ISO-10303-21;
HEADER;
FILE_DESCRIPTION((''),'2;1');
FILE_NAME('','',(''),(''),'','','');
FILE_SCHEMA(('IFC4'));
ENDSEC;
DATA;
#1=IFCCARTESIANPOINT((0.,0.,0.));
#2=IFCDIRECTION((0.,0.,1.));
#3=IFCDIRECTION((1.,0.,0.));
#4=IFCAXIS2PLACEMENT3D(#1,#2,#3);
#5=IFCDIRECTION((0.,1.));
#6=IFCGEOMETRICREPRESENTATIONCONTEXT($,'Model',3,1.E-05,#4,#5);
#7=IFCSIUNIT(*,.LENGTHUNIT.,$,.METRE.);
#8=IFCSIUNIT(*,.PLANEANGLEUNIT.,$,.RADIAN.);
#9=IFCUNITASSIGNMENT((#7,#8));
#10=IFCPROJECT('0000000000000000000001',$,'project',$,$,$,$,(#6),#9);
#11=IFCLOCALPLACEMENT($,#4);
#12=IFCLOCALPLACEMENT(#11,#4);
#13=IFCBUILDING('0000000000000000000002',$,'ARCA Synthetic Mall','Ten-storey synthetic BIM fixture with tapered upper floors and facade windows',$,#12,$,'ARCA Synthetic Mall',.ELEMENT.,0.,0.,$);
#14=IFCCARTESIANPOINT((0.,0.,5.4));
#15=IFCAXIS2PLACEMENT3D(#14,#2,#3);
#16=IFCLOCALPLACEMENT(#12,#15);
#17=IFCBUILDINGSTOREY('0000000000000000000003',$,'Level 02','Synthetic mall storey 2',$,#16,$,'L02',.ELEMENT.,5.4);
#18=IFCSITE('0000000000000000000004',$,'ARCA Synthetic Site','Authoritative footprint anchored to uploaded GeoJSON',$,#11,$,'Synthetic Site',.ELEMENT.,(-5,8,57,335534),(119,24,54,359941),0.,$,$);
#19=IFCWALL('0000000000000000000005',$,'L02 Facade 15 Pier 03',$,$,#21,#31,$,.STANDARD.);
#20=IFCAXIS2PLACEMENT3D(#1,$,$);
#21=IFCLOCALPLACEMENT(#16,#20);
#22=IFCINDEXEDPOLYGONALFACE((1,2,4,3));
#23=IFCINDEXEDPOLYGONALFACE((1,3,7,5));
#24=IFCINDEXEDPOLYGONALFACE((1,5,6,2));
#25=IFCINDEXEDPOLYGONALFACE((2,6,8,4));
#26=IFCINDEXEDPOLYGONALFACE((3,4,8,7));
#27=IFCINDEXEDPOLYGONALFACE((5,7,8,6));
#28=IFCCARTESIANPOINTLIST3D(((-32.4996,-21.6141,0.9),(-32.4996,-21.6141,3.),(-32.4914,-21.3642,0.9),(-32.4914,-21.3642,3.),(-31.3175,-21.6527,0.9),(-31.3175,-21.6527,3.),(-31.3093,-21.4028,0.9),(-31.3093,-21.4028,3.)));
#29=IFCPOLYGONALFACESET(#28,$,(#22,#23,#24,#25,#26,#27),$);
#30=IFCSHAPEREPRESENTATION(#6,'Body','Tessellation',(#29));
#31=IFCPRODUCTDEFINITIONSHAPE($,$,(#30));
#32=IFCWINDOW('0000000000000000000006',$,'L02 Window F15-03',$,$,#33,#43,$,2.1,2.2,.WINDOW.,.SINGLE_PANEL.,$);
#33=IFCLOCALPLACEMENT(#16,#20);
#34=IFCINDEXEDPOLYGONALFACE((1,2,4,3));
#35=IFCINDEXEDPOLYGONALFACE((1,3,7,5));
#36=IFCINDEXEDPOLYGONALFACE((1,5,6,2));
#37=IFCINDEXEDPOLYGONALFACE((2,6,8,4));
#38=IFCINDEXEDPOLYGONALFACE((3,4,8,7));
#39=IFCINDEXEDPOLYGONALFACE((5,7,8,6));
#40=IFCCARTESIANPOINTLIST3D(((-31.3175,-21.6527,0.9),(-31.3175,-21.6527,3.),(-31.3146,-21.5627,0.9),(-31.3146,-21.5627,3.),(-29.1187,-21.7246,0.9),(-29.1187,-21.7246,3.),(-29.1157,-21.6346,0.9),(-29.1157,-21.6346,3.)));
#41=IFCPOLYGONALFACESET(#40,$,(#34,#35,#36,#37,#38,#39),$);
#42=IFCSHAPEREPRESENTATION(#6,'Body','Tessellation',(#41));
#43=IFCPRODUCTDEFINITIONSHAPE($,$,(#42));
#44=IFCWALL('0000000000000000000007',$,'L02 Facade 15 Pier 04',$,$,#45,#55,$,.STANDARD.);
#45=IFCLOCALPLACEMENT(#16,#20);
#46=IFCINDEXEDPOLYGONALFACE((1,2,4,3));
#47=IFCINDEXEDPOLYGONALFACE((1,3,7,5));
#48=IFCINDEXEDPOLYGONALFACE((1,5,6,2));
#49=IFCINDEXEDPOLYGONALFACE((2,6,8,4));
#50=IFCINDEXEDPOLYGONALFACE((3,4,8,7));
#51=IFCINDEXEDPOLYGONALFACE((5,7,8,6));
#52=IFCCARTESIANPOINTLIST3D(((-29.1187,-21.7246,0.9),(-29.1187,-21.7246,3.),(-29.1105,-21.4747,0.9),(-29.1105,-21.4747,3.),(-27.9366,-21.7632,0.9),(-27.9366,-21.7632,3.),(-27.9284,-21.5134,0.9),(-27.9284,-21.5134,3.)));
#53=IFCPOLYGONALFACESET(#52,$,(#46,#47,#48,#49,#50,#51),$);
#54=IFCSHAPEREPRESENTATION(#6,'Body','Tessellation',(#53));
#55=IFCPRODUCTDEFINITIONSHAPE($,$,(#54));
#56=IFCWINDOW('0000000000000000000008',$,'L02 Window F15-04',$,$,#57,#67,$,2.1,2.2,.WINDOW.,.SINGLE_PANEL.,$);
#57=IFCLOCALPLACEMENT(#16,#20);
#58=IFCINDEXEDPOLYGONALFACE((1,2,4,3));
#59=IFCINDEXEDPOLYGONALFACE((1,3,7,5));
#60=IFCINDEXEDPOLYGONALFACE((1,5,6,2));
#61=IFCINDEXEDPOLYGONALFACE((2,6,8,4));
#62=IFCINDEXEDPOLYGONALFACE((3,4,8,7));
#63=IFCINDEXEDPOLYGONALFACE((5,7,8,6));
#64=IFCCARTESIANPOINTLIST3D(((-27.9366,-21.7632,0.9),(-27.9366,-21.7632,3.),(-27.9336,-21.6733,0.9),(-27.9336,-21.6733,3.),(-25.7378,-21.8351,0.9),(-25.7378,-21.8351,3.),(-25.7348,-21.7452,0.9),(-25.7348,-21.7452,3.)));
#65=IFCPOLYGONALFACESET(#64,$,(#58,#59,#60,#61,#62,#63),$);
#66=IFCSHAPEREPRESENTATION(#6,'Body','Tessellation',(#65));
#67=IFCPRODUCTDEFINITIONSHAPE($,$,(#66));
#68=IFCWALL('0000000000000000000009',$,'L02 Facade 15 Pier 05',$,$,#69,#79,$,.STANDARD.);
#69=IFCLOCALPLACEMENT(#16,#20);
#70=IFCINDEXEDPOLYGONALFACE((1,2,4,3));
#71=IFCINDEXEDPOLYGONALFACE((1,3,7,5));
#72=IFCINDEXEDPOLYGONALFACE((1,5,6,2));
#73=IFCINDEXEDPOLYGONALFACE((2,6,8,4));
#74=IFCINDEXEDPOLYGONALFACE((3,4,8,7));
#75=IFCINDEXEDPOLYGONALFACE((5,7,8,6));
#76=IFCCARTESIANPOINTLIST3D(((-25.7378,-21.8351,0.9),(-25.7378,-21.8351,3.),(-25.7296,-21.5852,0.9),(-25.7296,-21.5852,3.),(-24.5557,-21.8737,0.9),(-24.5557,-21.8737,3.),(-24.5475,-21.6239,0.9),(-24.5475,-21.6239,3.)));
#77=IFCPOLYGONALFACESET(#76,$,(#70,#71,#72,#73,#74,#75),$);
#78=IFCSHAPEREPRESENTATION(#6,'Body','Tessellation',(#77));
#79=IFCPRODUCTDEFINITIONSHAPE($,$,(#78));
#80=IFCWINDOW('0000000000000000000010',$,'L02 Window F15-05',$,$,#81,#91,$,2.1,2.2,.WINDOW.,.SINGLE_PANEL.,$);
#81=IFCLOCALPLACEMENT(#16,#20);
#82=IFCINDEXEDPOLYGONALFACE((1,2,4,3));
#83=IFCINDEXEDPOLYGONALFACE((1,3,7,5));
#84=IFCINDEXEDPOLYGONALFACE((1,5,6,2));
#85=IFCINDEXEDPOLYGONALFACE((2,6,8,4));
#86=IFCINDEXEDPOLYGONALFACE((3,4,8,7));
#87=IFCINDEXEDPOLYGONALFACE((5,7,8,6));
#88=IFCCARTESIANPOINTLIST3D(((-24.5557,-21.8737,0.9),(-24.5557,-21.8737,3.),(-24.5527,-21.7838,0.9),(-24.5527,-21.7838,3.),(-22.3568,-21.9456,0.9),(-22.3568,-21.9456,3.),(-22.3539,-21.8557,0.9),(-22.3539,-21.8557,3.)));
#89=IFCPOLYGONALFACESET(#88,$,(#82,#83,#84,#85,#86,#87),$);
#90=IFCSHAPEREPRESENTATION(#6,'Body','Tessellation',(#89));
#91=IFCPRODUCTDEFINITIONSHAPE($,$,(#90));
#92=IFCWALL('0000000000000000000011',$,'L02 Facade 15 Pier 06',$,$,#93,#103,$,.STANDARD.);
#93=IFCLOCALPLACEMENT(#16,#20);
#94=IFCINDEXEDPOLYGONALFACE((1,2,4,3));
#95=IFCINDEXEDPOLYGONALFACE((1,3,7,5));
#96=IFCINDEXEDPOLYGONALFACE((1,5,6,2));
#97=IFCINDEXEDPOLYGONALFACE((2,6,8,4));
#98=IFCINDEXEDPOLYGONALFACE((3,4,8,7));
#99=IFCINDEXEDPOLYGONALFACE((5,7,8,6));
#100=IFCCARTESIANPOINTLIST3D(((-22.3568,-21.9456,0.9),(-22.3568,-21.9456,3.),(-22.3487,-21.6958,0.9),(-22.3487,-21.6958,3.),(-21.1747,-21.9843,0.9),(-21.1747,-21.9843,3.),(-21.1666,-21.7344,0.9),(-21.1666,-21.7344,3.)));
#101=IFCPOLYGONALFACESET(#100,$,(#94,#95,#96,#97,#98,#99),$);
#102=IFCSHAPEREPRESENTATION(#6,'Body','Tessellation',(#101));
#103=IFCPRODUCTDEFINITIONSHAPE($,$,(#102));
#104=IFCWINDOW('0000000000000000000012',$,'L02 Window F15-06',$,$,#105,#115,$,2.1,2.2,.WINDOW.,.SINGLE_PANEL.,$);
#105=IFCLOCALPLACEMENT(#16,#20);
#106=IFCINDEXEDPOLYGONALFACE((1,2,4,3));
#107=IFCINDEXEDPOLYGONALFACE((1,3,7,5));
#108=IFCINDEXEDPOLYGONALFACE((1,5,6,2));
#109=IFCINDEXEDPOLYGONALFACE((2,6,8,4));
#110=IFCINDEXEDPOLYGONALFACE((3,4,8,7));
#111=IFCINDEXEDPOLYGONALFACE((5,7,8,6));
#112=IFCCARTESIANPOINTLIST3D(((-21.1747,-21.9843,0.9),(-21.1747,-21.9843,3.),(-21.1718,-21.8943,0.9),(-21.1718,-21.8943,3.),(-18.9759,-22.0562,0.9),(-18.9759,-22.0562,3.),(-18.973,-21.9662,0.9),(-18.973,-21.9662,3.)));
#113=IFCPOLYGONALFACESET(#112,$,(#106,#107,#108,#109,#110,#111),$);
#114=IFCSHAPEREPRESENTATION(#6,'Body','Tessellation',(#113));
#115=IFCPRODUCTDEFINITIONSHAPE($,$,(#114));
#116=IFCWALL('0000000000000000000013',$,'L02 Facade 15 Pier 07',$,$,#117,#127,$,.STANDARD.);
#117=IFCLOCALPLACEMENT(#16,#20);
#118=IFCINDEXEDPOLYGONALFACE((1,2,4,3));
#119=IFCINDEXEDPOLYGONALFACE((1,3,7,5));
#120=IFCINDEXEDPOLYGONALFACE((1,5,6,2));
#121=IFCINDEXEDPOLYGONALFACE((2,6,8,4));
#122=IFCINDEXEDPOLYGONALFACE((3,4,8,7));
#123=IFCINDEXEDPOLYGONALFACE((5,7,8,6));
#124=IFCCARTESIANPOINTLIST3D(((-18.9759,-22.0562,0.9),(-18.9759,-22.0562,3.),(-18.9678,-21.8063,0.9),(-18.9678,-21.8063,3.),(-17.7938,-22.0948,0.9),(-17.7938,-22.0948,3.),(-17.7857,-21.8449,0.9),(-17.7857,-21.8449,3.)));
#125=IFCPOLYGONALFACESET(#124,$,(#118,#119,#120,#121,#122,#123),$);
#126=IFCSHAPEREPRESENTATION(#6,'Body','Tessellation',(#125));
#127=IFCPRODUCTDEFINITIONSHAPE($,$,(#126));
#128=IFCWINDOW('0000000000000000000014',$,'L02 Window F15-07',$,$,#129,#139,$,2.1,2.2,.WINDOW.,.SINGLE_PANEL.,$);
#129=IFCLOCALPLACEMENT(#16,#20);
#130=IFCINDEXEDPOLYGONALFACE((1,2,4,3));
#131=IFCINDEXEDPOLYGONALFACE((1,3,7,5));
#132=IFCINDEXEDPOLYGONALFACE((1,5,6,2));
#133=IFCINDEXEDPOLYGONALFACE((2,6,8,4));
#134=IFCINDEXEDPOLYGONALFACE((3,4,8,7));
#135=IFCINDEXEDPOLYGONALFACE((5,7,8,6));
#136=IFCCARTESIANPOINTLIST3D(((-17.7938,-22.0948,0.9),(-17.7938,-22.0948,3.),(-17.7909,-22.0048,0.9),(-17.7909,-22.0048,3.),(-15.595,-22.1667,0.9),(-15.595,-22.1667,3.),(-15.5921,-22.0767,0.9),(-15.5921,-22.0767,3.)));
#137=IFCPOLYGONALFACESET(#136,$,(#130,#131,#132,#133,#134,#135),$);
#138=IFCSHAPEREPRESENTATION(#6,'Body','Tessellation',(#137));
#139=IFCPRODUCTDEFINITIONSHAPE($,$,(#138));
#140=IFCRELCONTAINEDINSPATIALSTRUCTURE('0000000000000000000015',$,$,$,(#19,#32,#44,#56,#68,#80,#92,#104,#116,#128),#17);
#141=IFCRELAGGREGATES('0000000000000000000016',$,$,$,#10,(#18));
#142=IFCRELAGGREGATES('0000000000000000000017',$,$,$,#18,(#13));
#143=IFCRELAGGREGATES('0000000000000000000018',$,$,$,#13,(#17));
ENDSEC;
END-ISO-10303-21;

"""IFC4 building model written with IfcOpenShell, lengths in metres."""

from ifc_helpers import new_model, si_unit, direction, frame, origin_with_axes, place, context, project, spatial, polyline, outline, extrude, element, save


model = new_model("IFC4")

# Units and contexts
model_context = context("Model", 3, precision=1e-05, world=origin_with_axes(), true_north=direction((0.0, 1.0)))
ifc_project = project(units=[si_unit("LENGTHUNIT", "METRE"), si_unit("PLANEANGLEUNIT", "RADIAN")], contexts=[model_context])

# Site, building, storey
site_placement = place(None, origin_with_axes())
site = spatial("IfcSite", under=ifc_project, at=site_placement, Name="ARCA Synthetic Site", Description="Authoritative footprint anchored to uploaded GeoJSON", LongName="Synthetic Site", CompositionType="ELEMENT", RefLatitude=(-5, 8, 57, 335534), RefLongitude=(119, 24, 54, 359941), RefElevation=0.0)
building_placement = place(site_placement, origin_with_axes())
building = spatial("IfcBuilding", under=site, at=building_placement, Name="ARCA Synthetic Mall", Description="Ten-storey synthetic BIM fixture with tapered upper floors and facade windows", LongName="ARCA Synthetic Mall", CompositionType="ELEMENT", ElevationOfRefHeight=0.0, ElevationOfTerrain=0.0)
storey_placement = place(building_placement, frame((0.0, 0.0, 5.4), z_axis=(0.0, 0.0, 1.0), x_axis=(1.0, 0.0, 0.0)))
storey = spatial("IfcBuildingStorey", under=building, at=storey_placement, Name="Level 02", Description="Synthetic mall storey 2", LongName="L02", CompositionType="ELEMENT", Elevation=5.4)

# Wall
wall_1_placement = place(storey_placement, frame((0.0, 0.0, 0.9), z_axis=(0.0, 0.0, 1.0), x_axis=(1.0, 0.0, 0.0)))
element("IfcWall", 1, at=wall_1_placement, inside=storey, Name="L02 Facade 15 Pier 03", PredefinedType="STANDARD", context=model_context, shape_type="SweptSolid", body=[
    extrude(outline(polyline([(-32.4996, -21.6141), (-31.3175, -21.6527), (-31.3093, -21.4028), (-32.4914, -21.3642), (-32.4996, -21.6141)])), origin_with_axes(), (0.0, 0.0, 1.0), 2.1),
])

# Window
window_1_placement = place(storey_placement, frame((0.0, 0.0, 0.9), z_axis=(0.0, 0.0, 1.0), x_axis=(1.0, 0.0, 0.0)))
element("IfcWindow", 2, at=window_1_placement, inside=storey, Name="L02 Window F15-03", OverallHeight=2.1, OverallWidth=2.2, PartitioningType="SINGLE_PANEL", PredefinedType="WINDOW", context=model_context, shape_type="SweptSolid", body=[
    extrude(outline(polyline([(-31.3175, -21.6527), (-29.1187, -21.7246), (-29.1157, -21.6346), (-31.3146, -21.5627), (-31.3175, -21.6527)])), origin_with_axes(), (0.0, 0.0, 1.0), 2.1),
])

# Wall
wall_2_placement = place(storey_placement, frame((0.0, 0.0, 0.9), z_axis=(0.0, 0.0, 1.0), x_axis=(1.0, 0.0, 0.0)))
element("IfcWall", 3, at=wall_2_placement, inside=storey, Name="L02 Facade 15 Pier 04", PredefinedType="STANDARD", context=model_context, shape_type="SweptSolid", body=[
    extrude(outline(polyline([(-29.1187, -21.7246), (-27.9366, -21.7632), (-27.9284, -21.5134), (-29.1105, -21.4747), (-29.1187, -21.7246)])), origin_with_axes(), (0.0, 0.0, 1.0), 2.1),
])

# Window
window_2_placement = place(storey_placement, frame((0.0, 0.0, 0.9), z_axis=(0.0, 0.0, 1.0), x_axis=(1.0, 0.0, 0.0)))
element("IfcWindow", 4, at=window_2_placement, inside=storey, Name="L02 Window F15-04", OverallHeight=2.1, OverallWidth=2.2, PartitioningType="SINGLE_PANEL", PredefinedType="WINDOW", context=model_context, shape_type="SweptSolid", body=[
    extrude(outline(polyline([(-27.9366, -21.7632), (-25.7378, -21.8351), (-25.7348, -21.7452), (-27.9336, -21.6733), (-27.9366, -21.7632)])), origin_with_axes(), (0.0, 0.0, 1.0), 2.1),
])

# Wall
wall_3_placement = place(storey_placement, frame((0.0, 0.0, 0.9), z_axis=(0.0, 0.0, 1.0), x_axis=(1.0, 0.0, 0.0)))
element("IfcWall", 5, at=wall_3_placement, inside=storey, Name="L02 Facade 15 Pier 05", PredefinedType="STANDARD", context=model_context, shape_type="SweptSolid", body=[
    extrude(outline(polyline([(-25.7378, -21.8351), (-24.5557, -21.8737), (-24.5475, -21.6239), (-25.7296, -21.5852), (-25.7378, -21.8351)])), origin_with_axes(), (0.0, 0.0, 1.0), 2.1),
])

# Window
window_3_placement = place(storey_placement, frame((0.0, 0.0, 0.9), z_axis=(0.0, 0.0, 1.0), x_axis=(1.0, 0.0, 0.0)))
element("IfcWindow", 6, at=window_3_placement, inside=storey, Name="L02 Window F15-05", OverallHeight=2.1, OverallWidth=2.2, PartitioningType="SINGLE_PANEL", PredefinedType="WINDOW", context=model_context, shape_type="SweptSolid", body=[
    extrude(outline(polyline([(-24.5557, -21.8737), (-22.3568, -21.9456), (-22.3539, -21.8557), (-24.5527, -21.7838), (-24.5557, -21.8737)])), origin_with_axes(), (0.0, 0.0, 1.0), 2.1),
])

# Wall
wall_4_placement = place(storey_placement, frame((0.0, 0.0, 0.9), z_axis=(0.0, 0.0, 1.0), x_axis=(1.0, 0.0, 0.0)))
element("IfcWall", 7, at=wall_4_placement, inside=storey, Name="L02 Facade 15 Pier 06", PredefinedType="STANDARD", context=model_context, shape_type="SweptSolid", body=[
    extrude(outline(polyline([(-22.3568, -21.9456), (-21.1747, -21.9843), (-21.1666, -21.7344), (-22.3487, -21.6958), (-22.3568, -21.9456)])), origin_with_axes(), (0.0, 0.0, 1.0), 2.1),
])

# Window
window_4_placement = place(storey_placement, frame((0.0, 0.0, 0.9), z_axis=(0.0, 0.0, 1.0), x_axis=(1.0, 0.0, 0.0)))
element("IfcWindow", 8, at=window_4_placement, inside=storey, Name="L02 Window F15-06", OverallHeight=2.1, OverallWidth=2.2, PartitioningType="SINGLE_PANEL", PredefinedType="WINDOW", context=model_context, shape_type="SweptSolid", body=[
    extrude(outline(polyline([(-21.1747, -21.9843), (-18.9759, -22.0562), (-18.973, -21.9662), (-21.1718, -21.8943), (-21.1747, -21.9843)])), origin_with_axes(), (0.0, 0.0, 1.0), 2.1),
])

# Wall
wall_5_placement = place(storey_placement, frame((0.0, 0.0, 0.9), z_axis=(0.0, 0.0, 1.0), x_axis=(1.0, 0.0, 0.0)))
element("IfcWall", 9, at=wall_5_placement, inside=storey, Name="L02 Facade 15 Pier 07", PredefinedType="STANDARD", context=model_context, shape_type="SweptSolid", body=[
    extrude(outline(polyline([(-18.9759, -22.0562), (-17.7938, -22.0948), (-17.7857, -21.8449), (-18.9678, -21.8063), (-18.9759, -22.0562)])), origin_with_axes(), (0.0, 0.0, 1.0), 2.1),
])

# Window
window_5_placement = place(storey_placement, frame((0.0, 0.0, 0.9), z_axis=(0.0, 0.0, 1.0), x_axis=(1.0, 0.0, 0.0)))
element("IfcWindow", 10, at=window_5_placement, inside=storey, Name="L02 Window F15-07", OverallHeight=2.1, OverallWidth=2.2, PartitioningType="SINGLE_PANEL", PredefinedType="WINDOW", context=model_context, shape_type="SweptSolid", body=[
    extrude(outline(polyline([(-17.7938, -22.0948), (-15.595, -22.1667), (-15.5921, -22.0767), (-17.7909, -22.0048), (-17.7938, -22.0948)])), origin_with_axes(), (0.0, 0.0, 1.0), 2.1),
])

save(model, "model.ifc")
